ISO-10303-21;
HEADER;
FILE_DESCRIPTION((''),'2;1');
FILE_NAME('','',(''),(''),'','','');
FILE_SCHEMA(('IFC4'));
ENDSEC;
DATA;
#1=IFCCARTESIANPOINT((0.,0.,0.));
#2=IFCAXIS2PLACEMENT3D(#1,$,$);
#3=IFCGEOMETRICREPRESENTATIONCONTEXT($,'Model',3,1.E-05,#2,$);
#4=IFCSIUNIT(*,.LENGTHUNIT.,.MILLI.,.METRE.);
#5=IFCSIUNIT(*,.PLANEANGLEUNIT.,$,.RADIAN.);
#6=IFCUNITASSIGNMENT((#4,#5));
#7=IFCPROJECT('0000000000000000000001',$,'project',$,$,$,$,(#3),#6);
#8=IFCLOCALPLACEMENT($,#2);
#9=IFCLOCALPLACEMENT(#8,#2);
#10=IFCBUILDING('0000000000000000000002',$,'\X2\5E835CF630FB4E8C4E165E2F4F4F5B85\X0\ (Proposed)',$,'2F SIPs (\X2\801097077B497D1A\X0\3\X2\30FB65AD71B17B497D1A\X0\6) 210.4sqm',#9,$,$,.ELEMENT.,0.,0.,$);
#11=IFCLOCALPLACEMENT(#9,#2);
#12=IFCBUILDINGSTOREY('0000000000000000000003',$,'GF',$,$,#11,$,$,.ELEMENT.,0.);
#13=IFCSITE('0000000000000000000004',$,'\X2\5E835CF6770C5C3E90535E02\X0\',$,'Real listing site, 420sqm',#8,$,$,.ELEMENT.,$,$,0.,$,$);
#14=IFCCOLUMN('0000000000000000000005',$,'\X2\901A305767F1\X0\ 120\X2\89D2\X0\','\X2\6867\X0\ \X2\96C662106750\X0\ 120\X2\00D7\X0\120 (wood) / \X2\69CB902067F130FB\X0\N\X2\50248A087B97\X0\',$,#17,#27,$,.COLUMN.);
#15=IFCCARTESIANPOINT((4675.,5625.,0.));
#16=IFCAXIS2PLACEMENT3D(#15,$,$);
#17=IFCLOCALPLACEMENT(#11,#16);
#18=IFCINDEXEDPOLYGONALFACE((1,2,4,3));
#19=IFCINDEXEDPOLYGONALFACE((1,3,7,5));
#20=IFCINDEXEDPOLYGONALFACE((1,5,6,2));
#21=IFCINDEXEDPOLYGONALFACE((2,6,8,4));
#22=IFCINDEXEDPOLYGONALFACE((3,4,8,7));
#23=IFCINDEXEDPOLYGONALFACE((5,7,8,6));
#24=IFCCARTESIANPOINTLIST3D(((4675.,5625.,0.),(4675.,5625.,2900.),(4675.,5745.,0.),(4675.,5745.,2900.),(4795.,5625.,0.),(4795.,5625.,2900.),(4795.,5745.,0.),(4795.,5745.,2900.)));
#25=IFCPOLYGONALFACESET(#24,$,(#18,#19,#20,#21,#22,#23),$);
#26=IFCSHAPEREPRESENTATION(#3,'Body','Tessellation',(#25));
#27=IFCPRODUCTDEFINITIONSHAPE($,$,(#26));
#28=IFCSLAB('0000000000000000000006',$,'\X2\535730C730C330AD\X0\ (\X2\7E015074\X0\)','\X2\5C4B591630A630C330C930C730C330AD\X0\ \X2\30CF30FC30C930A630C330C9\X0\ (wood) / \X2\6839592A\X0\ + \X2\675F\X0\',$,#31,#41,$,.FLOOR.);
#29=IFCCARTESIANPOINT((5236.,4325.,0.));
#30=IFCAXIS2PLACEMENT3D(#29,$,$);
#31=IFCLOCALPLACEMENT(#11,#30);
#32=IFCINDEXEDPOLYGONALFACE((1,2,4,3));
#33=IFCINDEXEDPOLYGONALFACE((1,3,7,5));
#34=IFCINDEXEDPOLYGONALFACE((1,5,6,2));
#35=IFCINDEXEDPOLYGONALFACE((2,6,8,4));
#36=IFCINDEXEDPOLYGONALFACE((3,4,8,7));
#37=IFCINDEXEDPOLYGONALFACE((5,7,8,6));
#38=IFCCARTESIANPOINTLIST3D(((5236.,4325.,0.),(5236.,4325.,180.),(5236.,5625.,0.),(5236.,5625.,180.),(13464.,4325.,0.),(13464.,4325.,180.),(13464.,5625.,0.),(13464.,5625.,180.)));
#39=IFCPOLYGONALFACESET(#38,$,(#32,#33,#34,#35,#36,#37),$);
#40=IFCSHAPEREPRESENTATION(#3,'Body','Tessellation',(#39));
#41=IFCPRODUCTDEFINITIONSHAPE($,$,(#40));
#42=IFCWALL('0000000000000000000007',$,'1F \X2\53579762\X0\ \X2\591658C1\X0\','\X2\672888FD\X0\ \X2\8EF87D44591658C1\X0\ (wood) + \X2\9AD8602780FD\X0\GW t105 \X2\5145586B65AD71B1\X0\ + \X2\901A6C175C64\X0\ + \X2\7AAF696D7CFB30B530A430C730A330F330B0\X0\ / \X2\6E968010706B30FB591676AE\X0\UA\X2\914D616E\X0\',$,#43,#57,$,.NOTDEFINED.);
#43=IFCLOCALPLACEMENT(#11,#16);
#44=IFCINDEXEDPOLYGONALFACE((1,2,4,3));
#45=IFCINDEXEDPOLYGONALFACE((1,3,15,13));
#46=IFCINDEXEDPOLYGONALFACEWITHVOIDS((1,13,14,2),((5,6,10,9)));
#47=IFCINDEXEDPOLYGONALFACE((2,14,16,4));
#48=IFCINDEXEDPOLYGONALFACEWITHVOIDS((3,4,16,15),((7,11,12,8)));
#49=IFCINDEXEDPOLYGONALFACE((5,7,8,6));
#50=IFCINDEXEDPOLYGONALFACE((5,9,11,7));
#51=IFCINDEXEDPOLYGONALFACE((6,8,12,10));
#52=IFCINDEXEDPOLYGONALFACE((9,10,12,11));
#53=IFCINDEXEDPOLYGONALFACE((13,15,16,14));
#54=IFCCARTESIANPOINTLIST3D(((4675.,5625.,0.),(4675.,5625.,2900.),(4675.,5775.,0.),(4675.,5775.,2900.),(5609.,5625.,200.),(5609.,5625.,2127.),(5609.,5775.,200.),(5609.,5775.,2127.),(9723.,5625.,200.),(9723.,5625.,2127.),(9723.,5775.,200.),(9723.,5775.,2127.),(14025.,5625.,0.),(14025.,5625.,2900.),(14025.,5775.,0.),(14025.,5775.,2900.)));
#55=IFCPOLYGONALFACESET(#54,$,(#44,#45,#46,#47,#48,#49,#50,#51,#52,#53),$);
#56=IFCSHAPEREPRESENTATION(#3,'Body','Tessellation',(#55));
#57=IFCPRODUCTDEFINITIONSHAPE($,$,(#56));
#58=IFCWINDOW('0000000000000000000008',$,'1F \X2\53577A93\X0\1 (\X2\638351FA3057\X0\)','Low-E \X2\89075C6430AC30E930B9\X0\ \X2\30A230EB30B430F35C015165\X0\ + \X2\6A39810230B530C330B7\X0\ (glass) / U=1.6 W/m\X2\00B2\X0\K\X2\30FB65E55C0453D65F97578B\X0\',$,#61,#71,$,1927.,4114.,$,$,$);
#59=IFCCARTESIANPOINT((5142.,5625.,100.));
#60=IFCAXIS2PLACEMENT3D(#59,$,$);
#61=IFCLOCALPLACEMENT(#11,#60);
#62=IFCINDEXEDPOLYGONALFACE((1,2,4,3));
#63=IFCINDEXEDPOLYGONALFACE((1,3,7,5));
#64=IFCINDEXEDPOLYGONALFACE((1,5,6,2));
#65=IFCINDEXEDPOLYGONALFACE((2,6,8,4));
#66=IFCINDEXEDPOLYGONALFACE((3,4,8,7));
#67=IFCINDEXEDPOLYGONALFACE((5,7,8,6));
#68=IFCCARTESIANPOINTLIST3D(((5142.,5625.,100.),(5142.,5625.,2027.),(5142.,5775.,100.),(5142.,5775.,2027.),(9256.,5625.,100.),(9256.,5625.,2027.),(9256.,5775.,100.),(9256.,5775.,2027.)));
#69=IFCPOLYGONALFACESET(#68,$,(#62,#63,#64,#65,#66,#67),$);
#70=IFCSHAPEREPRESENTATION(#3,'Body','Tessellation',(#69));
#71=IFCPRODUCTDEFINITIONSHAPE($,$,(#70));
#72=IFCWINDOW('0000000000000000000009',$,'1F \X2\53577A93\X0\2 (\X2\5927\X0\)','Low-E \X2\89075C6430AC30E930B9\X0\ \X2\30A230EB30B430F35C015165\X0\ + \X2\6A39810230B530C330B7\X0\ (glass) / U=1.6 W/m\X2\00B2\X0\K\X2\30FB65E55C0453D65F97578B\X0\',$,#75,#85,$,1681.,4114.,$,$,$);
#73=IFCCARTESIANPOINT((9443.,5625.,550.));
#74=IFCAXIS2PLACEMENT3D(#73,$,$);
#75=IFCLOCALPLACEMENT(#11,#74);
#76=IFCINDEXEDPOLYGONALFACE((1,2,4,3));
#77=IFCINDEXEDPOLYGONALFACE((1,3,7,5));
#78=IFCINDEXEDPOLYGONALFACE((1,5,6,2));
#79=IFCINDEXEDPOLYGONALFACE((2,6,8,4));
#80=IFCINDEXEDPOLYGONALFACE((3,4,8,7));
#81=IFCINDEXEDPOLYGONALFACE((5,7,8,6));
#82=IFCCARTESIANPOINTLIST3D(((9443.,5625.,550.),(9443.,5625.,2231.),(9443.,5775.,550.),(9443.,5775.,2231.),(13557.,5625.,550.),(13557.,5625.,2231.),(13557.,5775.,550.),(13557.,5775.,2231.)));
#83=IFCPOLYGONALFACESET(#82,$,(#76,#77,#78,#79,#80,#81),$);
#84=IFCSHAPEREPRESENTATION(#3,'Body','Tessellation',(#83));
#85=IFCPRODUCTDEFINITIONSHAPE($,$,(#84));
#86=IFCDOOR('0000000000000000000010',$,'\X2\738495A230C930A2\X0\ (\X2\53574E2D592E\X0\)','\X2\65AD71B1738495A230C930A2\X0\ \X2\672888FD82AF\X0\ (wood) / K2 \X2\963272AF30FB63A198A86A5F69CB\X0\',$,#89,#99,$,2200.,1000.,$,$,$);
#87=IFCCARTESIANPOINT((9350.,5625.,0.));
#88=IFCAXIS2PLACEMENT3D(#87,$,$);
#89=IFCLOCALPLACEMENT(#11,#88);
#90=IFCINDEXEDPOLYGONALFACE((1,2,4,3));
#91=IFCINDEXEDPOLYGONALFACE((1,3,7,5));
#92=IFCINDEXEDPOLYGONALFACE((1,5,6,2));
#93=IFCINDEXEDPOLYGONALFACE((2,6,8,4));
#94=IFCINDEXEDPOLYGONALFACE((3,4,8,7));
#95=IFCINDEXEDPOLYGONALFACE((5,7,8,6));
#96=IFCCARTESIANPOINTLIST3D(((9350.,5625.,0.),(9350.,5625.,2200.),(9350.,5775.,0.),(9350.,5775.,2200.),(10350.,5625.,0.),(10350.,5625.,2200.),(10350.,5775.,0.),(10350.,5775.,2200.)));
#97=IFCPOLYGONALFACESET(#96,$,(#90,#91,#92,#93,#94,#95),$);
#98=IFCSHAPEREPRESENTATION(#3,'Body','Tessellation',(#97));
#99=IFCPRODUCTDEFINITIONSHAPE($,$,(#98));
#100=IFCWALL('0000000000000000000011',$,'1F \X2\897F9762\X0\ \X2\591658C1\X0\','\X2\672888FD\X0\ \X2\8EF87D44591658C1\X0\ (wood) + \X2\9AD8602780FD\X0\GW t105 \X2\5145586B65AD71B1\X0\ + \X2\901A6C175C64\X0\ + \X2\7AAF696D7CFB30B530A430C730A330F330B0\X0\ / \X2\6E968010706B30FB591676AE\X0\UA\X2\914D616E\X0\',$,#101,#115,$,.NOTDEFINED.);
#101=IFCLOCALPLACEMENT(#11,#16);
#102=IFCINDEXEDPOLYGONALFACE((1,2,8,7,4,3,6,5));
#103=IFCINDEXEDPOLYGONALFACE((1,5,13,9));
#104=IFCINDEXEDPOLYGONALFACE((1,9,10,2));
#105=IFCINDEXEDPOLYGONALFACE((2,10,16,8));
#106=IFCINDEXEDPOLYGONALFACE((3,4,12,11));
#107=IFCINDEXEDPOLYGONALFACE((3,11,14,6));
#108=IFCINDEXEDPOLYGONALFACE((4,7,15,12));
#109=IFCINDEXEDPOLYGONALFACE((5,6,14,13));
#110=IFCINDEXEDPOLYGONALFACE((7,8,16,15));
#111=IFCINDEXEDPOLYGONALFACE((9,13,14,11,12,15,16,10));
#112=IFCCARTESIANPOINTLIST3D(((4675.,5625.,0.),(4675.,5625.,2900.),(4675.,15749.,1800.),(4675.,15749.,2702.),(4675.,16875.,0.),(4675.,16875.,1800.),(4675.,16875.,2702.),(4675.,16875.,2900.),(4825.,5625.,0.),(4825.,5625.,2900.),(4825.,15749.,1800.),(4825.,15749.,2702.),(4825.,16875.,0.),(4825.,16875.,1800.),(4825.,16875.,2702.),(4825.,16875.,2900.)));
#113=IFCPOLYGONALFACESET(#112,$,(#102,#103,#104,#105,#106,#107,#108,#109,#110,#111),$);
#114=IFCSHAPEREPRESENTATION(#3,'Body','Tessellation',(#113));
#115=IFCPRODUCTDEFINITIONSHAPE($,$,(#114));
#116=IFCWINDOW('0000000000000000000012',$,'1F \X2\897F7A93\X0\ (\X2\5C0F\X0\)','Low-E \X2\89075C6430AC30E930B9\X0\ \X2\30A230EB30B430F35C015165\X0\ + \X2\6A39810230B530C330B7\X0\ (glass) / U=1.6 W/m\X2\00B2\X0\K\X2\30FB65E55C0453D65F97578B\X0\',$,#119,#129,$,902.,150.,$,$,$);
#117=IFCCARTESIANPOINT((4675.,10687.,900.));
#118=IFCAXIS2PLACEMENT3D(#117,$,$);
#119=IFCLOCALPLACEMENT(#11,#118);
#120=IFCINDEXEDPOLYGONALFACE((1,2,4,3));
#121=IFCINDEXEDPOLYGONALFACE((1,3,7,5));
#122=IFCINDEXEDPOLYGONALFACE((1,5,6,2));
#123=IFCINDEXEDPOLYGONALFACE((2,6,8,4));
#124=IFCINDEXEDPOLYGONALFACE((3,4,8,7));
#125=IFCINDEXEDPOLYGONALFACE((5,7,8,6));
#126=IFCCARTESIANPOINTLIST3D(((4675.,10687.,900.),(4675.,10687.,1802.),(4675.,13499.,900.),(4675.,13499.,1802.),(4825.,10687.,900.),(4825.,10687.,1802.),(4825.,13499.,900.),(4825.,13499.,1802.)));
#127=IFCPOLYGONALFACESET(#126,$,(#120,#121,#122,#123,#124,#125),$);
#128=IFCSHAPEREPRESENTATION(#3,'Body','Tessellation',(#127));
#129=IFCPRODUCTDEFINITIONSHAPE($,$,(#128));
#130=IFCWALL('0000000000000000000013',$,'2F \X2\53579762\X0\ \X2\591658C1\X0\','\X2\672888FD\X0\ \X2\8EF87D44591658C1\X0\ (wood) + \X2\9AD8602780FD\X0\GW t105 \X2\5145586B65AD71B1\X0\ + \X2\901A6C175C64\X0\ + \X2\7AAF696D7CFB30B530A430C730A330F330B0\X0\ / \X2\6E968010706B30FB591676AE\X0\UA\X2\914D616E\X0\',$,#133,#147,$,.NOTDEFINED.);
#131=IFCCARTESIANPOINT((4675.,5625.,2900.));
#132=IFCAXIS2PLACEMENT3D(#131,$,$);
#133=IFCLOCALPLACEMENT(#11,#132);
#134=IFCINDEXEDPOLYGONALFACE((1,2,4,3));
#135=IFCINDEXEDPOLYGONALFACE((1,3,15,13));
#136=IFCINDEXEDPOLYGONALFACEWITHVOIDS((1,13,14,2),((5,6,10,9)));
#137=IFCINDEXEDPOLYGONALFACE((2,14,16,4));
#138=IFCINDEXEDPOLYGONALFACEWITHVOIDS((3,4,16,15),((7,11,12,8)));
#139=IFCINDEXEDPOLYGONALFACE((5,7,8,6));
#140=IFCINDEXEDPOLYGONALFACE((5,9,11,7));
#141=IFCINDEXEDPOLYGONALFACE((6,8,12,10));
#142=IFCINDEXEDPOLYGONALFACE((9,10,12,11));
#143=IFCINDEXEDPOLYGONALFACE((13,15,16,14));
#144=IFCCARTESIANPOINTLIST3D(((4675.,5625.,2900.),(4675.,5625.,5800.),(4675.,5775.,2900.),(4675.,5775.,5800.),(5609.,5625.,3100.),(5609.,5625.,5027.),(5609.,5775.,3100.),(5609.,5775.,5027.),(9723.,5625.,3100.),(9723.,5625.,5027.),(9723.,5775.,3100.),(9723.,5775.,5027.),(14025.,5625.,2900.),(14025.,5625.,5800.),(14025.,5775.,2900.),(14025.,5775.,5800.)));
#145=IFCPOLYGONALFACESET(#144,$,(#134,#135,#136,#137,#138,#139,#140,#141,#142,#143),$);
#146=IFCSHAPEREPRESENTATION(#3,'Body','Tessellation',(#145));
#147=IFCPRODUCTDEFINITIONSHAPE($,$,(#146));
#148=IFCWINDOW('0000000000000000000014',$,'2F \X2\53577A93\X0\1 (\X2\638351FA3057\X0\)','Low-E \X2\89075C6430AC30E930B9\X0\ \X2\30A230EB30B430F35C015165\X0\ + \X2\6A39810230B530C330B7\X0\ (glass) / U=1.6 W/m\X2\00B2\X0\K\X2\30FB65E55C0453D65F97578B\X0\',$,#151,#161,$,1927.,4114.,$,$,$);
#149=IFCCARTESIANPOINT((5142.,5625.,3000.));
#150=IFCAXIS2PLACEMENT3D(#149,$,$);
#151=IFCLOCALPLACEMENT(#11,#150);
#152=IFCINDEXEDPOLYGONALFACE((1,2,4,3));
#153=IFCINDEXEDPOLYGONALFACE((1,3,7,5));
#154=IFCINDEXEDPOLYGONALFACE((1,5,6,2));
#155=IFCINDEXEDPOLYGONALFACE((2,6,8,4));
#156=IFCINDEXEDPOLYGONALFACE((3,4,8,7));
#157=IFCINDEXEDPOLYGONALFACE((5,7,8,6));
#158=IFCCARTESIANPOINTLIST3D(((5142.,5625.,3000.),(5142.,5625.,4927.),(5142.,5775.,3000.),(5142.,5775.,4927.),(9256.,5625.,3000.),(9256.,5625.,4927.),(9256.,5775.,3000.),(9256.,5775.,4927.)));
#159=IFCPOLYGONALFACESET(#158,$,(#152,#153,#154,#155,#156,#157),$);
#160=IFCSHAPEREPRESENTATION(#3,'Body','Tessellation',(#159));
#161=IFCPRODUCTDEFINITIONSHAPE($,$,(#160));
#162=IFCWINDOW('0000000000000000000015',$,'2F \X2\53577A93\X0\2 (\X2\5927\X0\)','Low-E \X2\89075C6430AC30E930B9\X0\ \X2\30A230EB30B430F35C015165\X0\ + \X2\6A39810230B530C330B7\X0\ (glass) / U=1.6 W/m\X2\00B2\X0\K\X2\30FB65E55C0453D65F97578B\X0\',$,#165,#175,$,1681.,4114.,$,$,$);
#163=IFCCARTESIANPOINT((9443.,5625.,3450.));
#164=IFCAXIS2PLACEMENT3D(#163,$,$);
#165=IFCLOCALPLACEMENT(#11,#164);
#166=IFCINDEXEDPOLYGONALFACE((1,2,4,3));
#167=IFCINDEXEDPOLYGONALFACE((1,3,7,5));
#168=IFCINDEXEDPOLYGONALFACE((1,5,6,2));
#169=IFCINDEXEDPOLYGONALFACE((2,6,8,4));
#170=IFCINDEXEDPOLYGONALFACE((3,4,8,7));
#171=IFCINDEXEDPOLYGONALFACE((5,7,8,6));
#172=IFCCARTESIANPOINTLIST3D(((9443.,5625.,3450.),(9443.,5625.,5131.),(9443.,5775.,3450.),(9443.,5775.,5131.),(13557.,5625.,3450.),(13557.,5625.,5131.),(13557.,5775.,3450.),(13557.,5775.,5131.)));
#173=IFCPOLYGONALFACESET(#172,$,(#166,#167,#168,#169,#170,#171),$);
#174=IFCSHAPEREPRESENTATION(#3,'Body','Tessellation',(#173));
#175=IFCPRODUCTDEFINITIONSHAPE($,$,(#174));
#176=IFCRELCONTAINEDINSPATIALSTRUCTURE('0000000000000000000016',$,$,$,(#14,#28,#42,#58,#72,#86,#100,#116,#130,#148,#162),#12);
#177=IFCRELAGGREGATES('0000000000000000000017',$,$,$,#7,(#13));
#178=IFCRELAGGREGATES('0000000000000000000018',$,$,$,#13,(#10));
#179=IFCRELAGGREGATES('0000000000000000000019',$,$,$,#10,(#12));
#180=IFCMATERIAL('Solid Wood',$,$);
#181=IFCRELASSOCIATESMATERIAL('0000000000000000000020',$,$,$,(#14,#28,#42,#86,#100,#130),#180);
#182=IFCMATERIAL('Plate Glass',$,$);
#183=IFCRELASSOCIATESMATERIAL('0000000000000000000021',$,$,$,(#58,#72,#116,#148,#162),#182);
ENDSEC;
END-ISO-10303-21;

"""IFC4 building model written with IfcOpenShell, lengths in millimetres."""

from ifc_helpers import new_model, si_unit, frame, frame_2d, origin, place, context, project, spatial, rectangle, extrude, material, element, fill, save


model = new_model("IFC4")

# Units and contexts
model_context = context("Model", 3, precision=1e-05, world=origin())
ifc_project = project(units=[si_unit("LENGTHUNIT", "METRE", prefix="MILLI"), si_unit("PLANEANGLEUNIT", "RADIAN")], contexts=[model_context])

# Site, building, storey
site_placement = place(None, origin())
site = spatial("IfcSite", under=ifc_project, at=site_placement, Name="広島県尾道市", ObjectType="Real listing site, 420sqm", CompositionType="ELEMENT", RefElevation=0.0)
building_placement = place(site_placement, origin())
building = spatial("IfcBuilding", under=site, at=building_placement, Name="広島・二世帯住宅 (Proposed)", ObjectType="2F SIPs (耐震等級3・断熱等級6) 210.4sqm", CompositionType="ELEMENT", ElevationOfRefHeight=0.0, ElevationOfTerrain=0.0)
storey_placement = place(building_placement, origin())
storey = spatial("IfcBuildingStorey", under=building, at=storey_placement, Name="GF", CompositionType="ELEMENT", Elevation=0.0)

# Column
ifc_material_1 = material(Name="Solid Wood")
column_placement = place(storey_placement, frame((4675.0, 5625.0, 0.0)))
element("IfcColumn", 1, at=column_placement, inside=storey, material=ifc_material_1, Name="通し柱 120角", Description="桧 集成材 120×120 (wood) / 構造柱・N値計算", PredefinedType="COLUMN", context=model_context, shape_type="SweptSolid", body=[
    extrude(rectangle(XDim=120.0, YDim=120.0, at=frame_2d((60.0, 60.0))), frame((4675.0, 5625.0, 0.0)), (0.0, 0.0, 1.0), 2900.0),
])

# Slab
slab_1_placement = place(storey_placement, frame((5236.0, 4325.0, 0.0)))
element("IfcSlab", 2, at=slab_1_placement, inside=storey, material=ifc_material_1, Name="南デッキ (縁側)", Description="屋外ウッドデッキ ハードウッド (wood) / 根太 + 束", PredefinedType="FLOOR", context=model_context, shape_type="SweptSolid", body=[
    extrude(rectangle(XDim=8228.0, YDim=1300.0, at=frame_2d((4114.0, 650.0))), frame((5236.0, 4325.0, 0.0)), (0.0, 0.0, 1.0), 180.0),
])

# Wall, openings, windows, door
wall_1_placement = place(storey_placement, frame((4675.0, 5625.0, 0.0)))
wall_1 = element("IfcWall", 3, at=wall_1_placement, inside=storey, material=ifc_material_1, Name="1F 南面 外壁", Description="木製 軸組外壁 (wood) + 高性能GW t105 充填断熱 + 通気層 + 窯業系サイディング / 準耐火・外皮UA配慮", PredefinedType="NOTDEFINED", context=model_context, shape_type="SweptSolid", body=[
    extrude(rectangle(XDim=9350.0, YDim=150.0, at=frame_2d((4675.0, 75.0))), frame((4675.0, 5625.0, 0.0)), (0.0, 0.0, 1.0), 2900.0),
])
opening_1_placement = place(storey_placement, frame((5142.0, 5625.0, 100.0)))
opening_1 = element("IfcOpeningElement", 4, at=opening_1_placement, cuts=wall_1, PredefinedType="NOTDEFINED", context=model_context, shape_type="SweptSolid", body=[
    extrude(rectangle(XDim=4114.0, YDim=150.0, at=frame_2d((2057.0, 75.0))), frame((5142.0, 5625.0, 100.0)), (0.0, 0.0, 1.0), 1927.0),
])
opening_2_placement = place(storey_placement, frame((9443.0, 5625.0, 550.0)))
opening_2 = element("IfcOpeningElement", 5, at=opening_2_placement, cuts=wall_1, PredefinedType="NOTDEFINED", context=model_context, shape_type="SweptSolid", body=[
    extrude(rectangle(XDim=4114.0, YDim=150.0, at=frame_2d((2057.0, 75.0))), frame((9443.0, 5625.0, 550.0)), (0.0, 0.0, 1.0), 1681.0),
])
opening_3_placement = place(storey_placement, frame((9350.0, 5625.0, 0.0)))
opening_3 = element("IfcOpeningElement", 6, at=opening_3_placement, cuts=wall_1, PredefinedType="NOTDEFINED", context=model_context, shape_type="SweptSolid", body=[
    extrude(rectangle(XDim=1000.0, YDim=150.0, at=frame_2d((500.0, 75.0))), frame((9350.0, 5625.0, 0.0)), (0.0, 0.0, 1.0), 2200.0),
])
ifc_material_2 = material(Name="Plate Glass")
window_1_placement = place(storey_placement, frame((5142.0, 5625.0, 100.0)))
window_1 = element("IfcWindow", 7, at=window_1_placement, inside=storey, material=ifc_material_2, Name="1F 南窓1 (掃出し)", Description="Low-E 複層ガラス アルゴン封入 + 樹脂サッシ (glass) / U=1.6 W/m²K・日射取得型", OverallHeight=1927.0, OverallWidth=4114.0, context=model_context, shape_type="SweptSolid", body=[
    extrude(rectangle(XDim=4114.0, YDim=150.0, at=frame_2d((2057.0, 75.0))), frame((5142.0, 5625.0, 100.0)), (0.0, 0.0, 1.0), 1927.0),
])
fill(opening_1, window_1)
window_2_placement = place(storey_placement, frame((9443.0, 5625.0, 550.0)))
window_2 = element("IfcWindow", 8, at=window_2_placement, inside=storey, material=ifc_material_2, Name="1F 南窓2 (大)", Description="Low-E 複層ガラス アルゴン封入 + 樹脂サッシ (glass) / U=1.6 W/m²K・日射取得型", OverallHeight=1681.0, OverallWidth=4114.0, context=model_context, shape_type="SweptSolid", body=[
    extrude(rectangle(XDim=4114.0, YDim=150.0, at=frame_2d((2057.0, 75.0))), frame((9443.0, 5625.0, 550.0)), (0.0, 0.0, 1.0), 1681.0),
])
fill(opening_2, window_2)
door_placement = place(storey_placement, frame((9350.0, 5625.0, 0.0)))
door = element("IfcDoor", 9, at=door_placement, inside=storey, material=ifc_material_1, Name="玄関ドア (南中央)", Description="断熱玄関ドア 木製芯 (wood) / K2 防犯・採風機構", OverallHeight=2200.0, OverallWidth=1000.0, context=model_context, shape_type="SweptSolid", body=[
    extrude(rectangle(XDim=1000.0, YDim=150.0, at=frame_2d((500.0, 75.0))), frame((9350.0, 5625.0, 0.0)), (0.0, 0.0, 1.0), 2200.0),
])
fill(opening_3, door)

# Wall, opening, window
wall_2_placement = place(storey_placement, frame((4675.0, 5625.0, 0.0)))
wall_2 = element("IfcWall", 10, at=wall_2_placement, inside=storey, material=ifc_material_1, Name="1F 西面 外壁", Description="木製 軸組外壁 (wood) + 高性能GW t105 充填断熱 + 通気層 + 窯業系サイディング / 準耐火・外皮UA配慮", PredefinedType="NOTDEFINED", context=model_context, shape_type="SweptSolid", body=[
    extrude(rectangle(XDim=150.0, YDim=11250.0, at=frame_2d((75.0, 5625.0))), frame((4675.0, 5625.0, 0.0)), (0.0, 0.0, 1.0), 2900.0),
])
opening_4_placement = place(storey_placement, frame((4675.0, 10687.0, 900.0)))
opening_4 = element("IfcOpeningElement", 11, at=opening_4_placement, cuts=wall_2, PredefinedType="NOTDEFINED", context=model_context, shape_type="SweptSolid", body=[
    extrude(rectangle(XDim=150.0, YDim=2812.0, at=frame_2d((75.0, 1406.0))), frame((4675.0, 10687.0, 900.0)), (0.0, 0.0, 1.0), 902.0),
])
window_3_placement = place(storey_placement, frame((4675.0, 10687.0, 900.0)))
window_3 = element("IfcWindow", 12, at=window_3_placement, inside=storey, material=ifc_material_2, Name="1F 西窓 (小)", Description="Low-E 複層ガラス アルゴン封入 + 樹脂サッシ (glass) / U=1.6 W/m²K・日射取得型", OverallHeight=902.0, OverallWidth=150.0, context=model_context, shape_type="SweptSolid", body=[
    extrude(rectangle(XDim=150.0, YDim=2812.0, at=frame_2d((75.0, 1406.0))), frame((4675.0, 10687.0, 900.0)), (0.0, 0.0, 1.0), 902.0),
])
fill(opening_4, window_3)

# Wall, openings, windows
wall_3_placement = place(storey_placement, frame((4675.0, 5625.0, 2900.0)))
wall_3 = element("IfcWall", 13, at=wall_3_placement, inside=storey, material=ifc_material_1, Name="2F 南面 外壁", Description="木製 軸組外壁 (wood) + 高性能GW t105 充填断熱 + 通気層 + 窯業系サイディング / 準耐火・外皮UA配慮", PredefinedType="NOTDEFINED", context=model_context, shape_type="SweptSolid", body=[
    extrude(rectangle(XDim=9350.0, YDim=150.0, at=frame_2d((4675.0, 75.0))), frame((4675.0, 5625.0, 2900.0)), (0.0, 0.0, 1.0), 2900.0),
])
opening_5_placement = place(storey_placement, frame((5142.0, 5625.0, 3000.0)))
opening_5 = element("IfcOpeningElement", 14, at=opening_5_placement, cuts=wall_3, PredefinedType="NOTDEFINED", context=model_context, shape_type="SweptSolid", body=[
    extrude(rectangle(XDim=4114.0, YDim=150.0, at=frame_2d((2057.0, 75.0))), frame((5142.0, 5625.0, 3000.0)), (0.0, 0.0, 1.0), 1927.0),
])
opening_6_placement = place(storey_placement, frame((9443.0, 5625.0, 3450.0)))
opening_6 = element("IfcOpeningElement", 15, at=opening_6_placement, cuts=wall_3, PredefinedType="NOTDEFINED", context=model_context, shape_type="SweptSolid", body=[
    extrude(rectangle(XDim=4114.0, YDim=150.0, at=frame_2d((2057.0, 75.0))), frame((9443.0, 5625.0, 3450.0)), (0.0, 0.0, 1.0), 1681.0),
])
window_4_placement = place(storey_placement, frame((5142.0, 5625.0, 3000.0)))
window_4 = element("IfcWindow", 16, at=window_4_placement, inside=storey, material=ifc_material_2, Name="2F 南窓1 (掃出し)", Description="Low-E 複層ガラス アルゴン封入 + 樹脂サッシ (glass) / U=1.6 W/m²K・日射取得型", OverallHeight=1927.0, OverallWidth=4114.0, context=model_context, shape_type="SweptSolid", body=[
    extrude(rectangle(XDim=4114.0, YDim=150.0, at=frame_2d((2057.0, 75.0))), frame((5142.0, 5625.0, 3000.0)), (0.0, 0.0, 1.0), 1927.0),
])
fill(opening_5, window_4)
window_5_placement = place(storey_placement, frame((9443.0, 5625.0, 3450.0)))
window_5 = element("IfcWindow", 17, at=window_5_placement, inside=storey, material=ifc_material_2, Name="2F 南窓2 (大)", Description="Low-E 複層ガラス アルゴン封入 + 樹脂サッシ (glass) / U=1.6 W/m²K・日射取得型", OverallHeight=1681.0, OverallWidth=4114.0, context=model_context, shape_type="SweptSolid", body=[
    extrude(rectangle(XDim=4114.0, YDim=150.0, at=frame_2d((2057.0, 75.0))), frame((9443.0, 5625.0, 3450.0)), (0.0, 0.0, 1.0), 1681.0),
])
fill(opening_6, window_5)

save(model, "model.ifc")
